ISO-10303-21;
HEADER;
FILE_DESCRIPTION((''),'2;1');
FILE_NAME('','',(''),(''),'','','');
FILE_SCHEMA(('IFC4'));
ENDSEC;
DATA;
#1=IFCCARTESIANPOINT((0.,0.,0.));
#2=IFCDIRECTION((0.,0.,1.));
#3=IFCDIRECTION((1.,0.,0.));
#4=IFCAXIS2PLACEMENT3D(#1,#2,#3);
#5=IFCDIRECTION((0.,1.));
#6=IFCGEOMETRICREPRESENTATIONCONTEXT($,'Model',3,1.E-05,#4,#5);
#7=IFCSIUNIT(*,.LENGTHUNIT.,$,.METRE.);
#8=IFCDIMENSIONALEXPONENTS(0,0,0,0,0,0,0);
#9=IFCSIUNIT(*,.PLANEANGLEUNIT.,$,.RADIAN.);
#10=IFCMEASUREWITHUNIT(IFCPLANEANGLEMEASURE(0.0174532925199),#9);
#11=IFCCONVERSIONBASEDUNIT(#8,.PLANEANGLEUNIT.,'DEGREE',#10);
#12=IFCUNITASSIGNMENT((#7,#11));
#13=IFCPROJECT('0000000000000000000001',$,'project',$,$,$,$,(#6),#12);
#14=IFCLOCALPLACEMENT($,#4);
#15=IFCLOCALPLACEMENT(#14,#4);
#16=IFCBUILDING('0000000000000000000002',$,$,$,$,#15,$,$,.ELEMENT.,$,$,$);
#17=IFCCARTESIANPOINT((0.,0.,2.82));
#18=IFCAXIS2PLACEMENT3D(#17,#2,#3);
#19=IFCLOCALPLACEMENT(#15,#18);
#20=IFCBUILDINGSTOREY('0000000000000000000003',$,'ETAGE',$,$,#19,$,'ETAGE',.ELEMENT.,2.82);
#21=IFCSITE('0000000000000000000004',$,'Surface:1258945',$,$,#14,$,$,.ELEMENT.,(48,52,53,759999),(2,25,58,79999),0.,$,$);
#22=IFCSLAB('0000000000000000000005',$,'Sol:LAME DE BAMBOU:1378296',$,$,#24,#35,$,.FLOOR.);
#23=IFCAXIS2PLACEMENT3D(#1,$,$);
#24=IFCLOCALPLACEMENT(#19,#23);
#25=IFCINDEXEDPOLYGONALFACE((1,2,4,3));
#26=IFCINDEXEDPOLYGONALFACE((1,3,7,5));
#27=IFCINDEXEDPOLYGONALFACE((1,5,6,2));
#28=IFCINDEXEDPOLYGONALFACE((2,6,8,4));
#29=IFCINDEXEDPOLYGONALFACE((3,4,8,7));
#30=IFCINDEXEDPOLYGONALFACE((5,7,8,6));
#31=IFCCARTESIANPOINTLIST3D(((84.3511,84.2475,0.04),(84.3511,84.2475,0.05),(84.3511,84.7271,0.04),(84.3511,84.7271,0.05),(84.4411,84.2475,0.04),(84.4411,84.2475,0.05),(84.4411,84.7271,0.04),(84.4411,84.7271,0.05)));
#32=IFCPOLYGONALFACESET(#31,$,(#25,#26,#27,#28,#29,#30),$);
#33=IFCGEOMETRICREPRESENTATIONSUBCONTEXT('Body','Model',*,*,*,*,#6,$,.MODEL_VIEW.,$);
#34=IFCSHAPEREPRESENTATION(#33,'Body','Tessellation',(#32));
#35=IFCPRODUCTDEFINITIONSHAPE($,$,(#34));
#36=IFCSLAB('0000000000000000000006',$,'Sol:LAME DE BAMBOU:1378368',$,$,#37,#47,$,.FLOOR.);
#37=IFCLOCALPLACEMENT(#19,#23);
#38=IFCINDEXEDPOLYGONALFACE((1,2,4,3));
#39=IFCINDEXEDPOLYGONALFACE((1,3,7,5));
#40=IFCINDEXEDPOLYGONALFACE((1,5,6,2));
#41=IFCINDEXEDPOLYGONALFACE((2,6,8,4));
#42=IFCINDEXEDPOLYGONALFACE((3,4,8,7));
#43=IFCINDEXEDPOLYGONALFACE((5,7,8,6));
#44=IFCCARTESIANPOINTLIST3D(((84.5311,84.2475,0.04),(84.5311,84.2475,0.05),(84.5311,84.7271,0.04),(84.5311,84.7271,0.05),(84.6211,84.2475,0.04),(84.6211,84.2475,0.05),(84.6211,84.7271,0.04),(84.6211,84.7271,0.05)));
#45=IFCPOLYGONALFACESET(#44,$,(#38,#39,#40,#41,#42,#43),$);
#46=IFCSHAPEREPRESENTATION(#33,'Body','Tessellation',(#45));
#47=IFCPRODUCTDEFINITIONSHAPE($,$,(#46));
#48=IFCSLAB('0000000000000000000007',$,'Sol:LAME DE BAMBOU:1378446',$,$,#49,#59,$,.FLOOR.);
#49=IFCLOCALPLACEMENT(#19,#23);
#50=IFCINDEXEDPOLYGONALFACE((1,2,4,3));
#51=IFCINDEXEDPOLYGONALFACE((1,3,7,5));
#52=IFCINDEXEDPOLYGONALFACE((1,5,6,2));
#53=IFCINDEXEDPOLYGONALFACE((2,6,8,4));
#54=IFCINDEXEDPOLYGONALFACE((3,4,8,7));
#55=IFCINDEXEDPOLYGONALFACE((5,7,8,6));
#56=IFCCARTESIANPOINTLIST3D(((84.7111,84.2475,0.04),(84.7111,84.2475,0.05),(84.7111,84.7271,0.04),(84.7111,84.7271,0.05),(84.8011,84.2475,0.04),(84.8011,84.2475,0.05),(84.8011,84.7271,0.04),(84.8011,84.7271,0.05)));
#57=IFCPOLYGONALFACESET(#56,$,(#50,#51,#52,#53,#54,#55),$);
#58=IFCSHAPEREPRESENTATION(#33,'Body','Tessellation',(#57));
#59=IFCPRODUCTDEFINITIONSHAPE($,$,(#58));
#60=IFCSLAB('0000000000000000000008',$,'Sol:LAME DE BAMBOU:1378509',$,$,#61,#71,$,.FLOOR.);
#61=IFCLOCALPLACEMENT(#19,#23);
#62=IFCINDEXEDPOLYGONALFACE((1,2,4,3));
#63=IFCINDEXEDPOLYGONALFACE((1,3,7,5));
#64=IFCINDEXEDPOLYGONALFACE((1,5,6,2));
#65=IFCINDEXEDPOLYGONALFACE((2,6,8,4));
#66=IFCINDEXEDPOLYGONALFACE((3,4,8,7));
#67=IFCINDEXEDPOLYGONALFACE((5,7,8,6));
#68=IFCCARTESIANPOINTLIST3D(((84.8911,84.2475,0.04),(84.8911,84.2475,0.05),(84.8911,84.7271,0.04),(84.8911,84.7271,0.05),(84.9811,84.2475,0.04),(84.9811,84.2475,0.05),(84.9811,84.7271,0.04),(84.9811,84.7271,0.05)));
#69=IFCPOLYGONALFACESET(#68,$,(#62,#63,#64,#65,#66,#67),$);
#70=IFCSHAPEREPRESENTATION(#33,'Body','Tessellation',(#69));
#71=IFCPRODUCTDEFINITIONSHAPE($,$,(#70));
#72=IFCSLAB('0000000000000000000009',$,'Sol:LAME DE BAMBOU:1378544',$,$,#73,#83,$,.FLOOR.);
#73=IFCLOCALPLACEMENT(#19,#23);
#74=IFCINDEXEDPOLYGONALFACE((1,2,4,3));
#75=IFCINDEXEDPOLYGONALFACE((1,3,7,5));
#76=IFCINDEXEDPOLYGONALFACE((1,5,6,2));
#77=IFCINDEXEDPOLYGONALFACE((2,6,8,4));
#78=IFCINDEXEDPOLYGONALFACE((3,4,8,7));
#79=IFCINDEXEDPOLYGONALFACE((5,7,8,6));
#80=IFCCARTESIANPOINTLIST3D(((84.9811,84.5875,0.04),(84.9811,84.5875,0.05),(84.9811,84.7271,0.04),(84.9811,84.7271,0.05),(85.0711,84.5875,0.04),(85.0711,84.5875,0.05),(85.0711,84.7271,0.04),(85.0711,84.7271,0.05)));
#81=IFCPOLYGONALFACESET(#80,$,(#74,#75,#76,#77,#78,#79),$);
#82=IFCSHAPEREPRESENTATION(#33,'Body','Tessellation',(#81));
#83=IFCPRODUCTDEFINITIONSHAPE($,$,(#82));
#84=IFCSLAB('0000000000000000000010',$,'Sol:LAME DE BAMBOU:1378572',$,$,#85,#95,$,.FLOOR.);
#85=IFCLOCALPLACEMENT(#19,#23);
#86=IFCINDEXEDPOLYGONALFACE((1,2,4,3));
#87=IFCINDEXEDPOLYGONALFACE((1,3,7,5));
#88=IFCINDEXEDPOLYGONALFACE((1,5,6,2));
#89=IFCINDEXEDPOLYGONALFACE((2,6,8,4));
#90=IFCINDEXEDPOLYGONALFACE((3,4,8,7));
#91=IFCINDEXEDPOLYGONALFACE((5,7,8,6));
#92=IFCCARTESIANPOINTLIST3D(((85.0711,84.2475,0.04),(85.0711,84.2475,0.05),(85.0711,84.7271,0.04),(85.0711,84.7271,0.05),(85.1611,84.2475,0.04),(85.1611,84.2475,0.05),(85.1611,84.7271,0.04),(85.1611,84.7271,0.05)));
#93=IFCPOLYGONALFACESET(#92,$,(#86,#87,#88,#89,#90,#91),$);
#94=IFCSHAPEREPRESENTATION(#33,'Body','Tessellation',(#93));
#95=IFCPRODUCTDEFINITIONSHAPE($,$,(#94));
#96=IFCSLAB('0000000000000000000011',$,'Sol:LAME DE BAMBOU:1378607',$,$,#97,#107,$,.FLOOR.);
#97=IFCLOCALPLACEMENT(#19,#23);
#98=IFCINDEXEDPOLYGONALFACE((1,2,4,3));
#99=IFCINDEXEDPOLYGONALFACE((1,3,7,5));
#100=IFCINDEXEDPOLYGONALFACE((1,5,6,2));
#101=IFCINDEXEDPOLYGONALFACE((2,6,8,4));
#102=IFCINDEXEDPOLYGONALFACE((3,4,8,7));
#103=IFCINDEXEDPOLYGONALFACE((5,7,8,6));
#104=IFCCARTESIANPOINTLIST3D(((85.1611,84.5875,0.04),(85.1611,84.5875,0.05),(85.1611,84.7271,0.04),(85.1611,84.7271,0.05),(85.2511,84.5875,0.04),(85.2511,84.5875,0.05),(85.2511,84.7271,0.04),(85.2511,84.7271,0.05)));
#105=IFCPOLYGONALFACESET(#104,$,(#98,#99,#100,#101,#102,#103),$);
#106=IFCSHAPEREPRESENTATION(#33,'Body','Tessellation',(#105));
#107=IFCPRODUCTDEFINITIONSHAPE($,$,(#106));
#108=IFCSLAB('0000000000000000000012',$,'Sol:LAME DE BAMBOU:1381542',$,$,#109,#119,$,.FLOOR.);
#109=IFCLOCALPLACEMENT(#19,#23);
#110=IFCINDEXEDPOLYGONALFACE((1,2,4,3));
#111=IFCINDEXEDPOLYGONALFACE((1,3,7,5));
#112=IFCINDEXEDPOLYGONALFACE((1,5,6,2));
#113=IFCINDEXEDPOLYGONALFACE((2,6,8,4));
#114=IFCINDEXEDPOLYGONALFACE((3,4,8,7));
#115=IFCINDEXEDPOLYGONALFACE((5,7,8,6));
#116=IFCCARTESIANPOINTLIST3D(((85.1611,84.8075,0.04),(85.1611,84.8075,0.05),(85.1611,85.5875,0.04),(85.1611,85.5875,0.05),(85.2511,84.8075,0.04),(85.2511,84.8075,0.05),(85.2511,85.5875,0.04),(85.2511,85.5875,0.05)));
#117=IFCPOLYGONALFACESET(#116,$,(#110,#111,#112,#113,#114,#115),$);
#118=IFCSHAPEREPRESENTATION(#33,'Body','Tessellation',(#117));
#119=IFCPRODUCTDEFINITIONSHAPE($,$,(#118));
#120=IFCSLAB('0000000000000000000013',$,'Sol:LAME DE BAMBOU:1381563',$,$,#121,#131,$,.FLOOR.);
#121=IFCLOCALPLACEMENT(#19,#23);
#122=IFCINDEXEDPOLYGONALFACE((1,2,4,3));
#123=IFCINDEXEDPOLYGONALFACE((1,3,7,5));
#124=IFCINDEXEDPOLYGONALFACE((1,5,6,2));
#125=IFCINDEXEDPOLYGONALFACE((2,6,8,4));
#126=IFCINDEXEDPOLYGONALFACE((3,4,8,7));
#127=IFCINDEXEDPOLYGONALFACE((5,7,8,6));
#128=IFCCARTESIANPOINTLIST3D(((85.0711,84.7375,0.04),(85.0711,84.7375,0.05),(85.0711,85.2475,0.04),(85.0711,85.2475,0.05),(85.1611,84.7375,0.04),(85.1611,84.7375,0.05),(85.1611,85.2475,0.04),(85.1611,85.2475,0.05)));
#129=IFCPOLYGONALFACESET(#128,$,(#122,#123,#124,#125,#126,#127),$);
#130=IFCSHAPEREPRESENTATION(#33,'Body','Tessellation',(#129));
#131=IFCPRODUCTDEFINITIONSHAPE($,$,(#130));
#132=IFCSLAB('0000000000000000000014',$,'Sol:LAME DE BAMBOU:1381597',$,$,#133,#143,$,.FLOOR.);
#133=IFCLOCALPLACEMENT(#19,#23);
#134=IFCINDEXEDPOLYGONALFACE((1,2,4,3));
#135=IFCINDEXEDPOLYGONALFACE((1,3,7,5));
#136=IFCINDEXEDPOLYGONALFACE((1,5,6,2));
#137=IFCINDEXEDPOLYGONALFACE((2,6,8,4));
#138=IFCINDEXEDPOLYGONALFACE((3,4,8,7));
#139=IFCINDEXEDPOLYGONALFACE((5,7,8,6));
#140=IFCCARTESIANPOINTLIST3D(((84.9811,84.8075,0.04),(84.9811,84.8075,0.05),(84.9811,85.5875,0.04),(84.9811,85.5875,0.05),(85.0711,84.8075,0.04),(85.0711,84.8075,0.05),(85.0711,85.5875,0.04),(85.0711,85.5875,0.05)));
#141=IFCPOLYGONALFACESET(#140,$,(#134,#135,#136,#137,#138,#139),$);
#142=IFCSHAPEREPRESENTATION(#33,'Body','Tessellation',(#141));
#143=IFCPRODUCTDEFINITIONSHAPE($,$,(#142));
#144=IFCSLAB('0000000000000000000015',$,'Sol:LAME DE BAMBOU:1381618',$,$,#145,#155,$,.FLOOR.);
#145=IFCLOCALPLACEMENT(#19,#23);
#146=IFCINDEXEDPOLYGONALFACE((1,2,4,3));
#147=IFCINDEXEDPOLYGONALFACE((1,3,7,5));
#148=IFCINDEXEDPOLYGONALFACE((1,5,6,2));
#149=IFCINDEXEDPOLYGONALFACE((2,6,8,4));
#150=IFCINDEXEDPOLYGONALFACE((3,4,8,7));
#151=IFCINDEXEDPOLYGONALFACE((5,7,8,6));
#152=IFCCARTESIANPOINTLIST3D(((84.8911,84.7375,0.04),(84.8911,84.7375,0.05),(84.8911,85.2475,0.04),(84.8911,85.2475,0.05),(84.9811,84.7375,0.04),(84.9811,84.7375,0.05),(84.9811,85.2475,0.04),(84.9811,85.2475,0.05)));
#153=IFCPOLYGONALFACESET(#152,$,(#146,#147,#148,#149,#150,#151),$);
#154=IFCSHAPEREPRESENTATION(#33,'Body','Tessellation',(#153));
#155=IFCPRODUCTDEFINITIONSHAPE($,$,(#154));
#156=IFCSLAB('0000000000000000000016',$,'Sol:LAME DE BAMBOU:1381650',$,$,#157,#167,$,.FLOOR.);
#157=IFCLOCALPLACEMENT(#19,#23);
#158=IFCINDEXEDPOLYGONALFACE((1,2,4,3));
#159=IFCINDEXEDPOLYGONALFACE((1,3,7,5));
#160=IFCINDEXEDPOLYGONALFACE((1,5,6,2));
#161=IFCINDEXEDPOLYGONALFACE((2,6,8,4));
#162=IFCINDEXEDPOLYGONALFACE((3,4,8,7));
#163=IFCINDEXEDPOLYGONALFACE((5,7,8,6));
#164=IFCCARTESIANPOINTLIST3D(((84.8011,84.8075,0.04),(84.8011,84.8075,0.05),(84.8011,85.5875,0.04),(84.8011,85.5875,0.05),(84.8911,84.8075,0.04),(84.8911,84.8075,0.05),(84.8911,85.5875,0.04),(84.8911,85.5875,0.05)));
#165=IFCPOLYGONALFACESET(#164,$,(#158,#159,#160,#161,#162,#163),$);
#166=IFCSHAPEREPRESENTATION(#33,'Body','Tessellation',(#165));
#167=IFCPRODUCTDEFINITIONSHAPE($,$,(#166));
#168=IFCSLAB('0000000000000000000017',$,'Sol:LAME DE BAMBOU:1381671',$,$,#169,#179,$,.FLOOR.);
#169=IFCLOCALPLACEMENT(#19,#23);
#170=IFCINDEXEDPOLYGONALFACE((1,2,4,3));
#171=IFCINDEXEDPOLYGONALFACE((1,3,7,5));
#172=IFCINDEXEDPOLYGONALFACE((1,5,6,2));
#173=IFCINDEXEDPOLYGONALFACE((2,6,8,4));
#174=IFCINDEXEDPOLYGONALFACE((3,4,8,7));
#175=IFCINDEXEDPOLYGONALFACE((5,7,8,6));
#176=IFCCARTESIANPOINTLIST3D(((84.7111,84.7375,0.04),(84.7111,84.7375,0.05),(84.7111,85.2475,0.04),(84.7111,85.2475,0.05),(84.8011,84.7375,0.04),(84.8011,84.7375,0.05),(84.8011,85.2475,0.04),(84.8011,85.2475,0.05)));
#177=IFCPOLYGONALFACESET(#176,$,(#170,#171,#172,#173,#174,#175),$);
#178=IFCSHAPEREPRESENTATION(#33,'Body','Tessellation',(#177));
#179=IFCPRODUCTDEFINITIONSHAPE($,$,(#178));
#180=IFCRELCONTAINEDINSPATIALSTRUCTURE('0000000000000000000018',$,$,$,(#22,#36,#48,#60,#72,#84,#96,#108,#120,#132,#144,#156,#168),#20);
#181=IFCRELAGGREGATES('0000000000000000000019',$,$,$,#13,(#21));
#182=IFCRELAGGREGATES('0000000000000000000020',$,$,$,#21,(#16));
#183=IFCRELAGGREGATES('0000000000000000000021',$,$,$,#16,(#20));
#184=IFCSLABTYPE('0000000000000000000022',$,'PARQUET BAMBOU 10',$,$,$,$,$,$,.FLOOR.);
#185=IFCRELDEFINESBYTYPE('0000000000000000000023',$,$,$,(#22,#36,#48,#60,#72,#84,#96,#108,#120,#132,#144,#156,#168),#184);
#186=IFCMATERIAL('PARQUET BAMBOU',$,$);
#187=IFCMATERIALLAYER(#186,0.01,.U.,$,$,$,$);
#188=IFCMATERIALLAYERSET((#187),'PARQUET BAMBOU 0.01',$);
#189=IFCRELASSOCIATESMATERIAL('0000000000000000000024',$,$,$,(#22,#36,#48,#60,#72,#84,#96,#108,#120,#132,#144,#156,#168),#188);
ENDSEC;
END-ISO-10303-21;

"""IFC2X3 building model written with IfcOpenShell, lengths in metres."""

from ifc_helpers import new_model, entity, si_unit, converted_unit, direction, frame, origin_with_axes, place, context, subcontext, project, spatial, polyline, outline, extrude, material, layer, layer_set, layer_usage, type_object, element, save


model = new_model("IFC2X3")

# Units and contexts
model_context = context("Model", 3, precision=1e-05, world=origin_with_axes(), true_north=direction((0.0, 1.0)))
body_context = subcontext(model_context, "Body", "Model", "MODEL_VIEW")
ifc_project = project(units=[si_unit("LENGTHUNIT", "METRE"), converted_unit("PLANEANGLEUNIT", "DEGREE", entity("IfcPlaneAngleMeasure", 0.0174532925199), si_unit("PLANEANGLEUNIT", "RADIAN"), dimensions=[0, 0, 0, 0, 0, 0, 0])], contexts=[model_context])

# Site, building, storey
site_placement = place(None, origin_with_axes())
site = spatial("IfcSite", under=ifc_project, at=site_placement, Name="Surface:1258945", CompositionType="ELEMENT", RefLatitude=(48, 52, 53, 759999), RefLongitude=(2, 25, 58, 79999), RefElevation=0.0)
building_placement = place(site_placement, origin_with_axes())
building = spatial("IfcBuilding", under=site, at=building_placement, CompositionType="ELEMENT")
storey_placement = place(building_placement, frame((0.0, 0.0, 2.82), z_axis=(0.0, 0.0, 1.0), x_axis=(1.0, 0.0, 0.0)))
storey = spatial("IfcBuildingStorey", under=building, at=storey_placement, Name="ETAGE", LongName="ETAGE", CompositionType="ELEMENT", Elevation=2.82)

# Slabs
ifc_material_1 = material(Name="PARQUET BAMBOU")
ifc_layer_1 = layer(ifc_material_1, 0.01, ventilated="UNKNOWN")
ifc_layer_set_1 = layer_set([ifc_layer_1], Name="PARQUET BAMBOU 0.01")
ifc_layer_usage_1 = layer_usage(ifc_layer_set_1, "AXIS3", "NEGATIVE", 0.01)
slab_type = type_object("IfcSlabType", Name="PARQUET BAMBOU 10", PredefinedType="FLOOR")
slab_1_placement = place(storey_placement, frame((84.3511, 84.7271, 0.05), z_axis=(0.0, 0.0, 1.0), x_axis=(1.0, 0.0, 0.0)))
element("IfcSlab", 1, at=slab_1_placement, inside=storey, type_object=slab_type, material=ifc_layer_usage_1, Name="Sol:LAME DE BAMBOU:1378296", PredefinedType="FLOOR", context=body_context, shape_type="SweptSolid", body=[
    extrude(outline(polyline([(0.0, 0.0), (0.0, -0.4796), (0.09, -0.4796), (0.09, 0.0), (0.0, 0.0)])), frame((0.0, 0.0, -0.01), z_axis=(0.0, 0.0, 1.0), x_axis=(1.0, 0.0, 0.0)), (0.0, 0.0, 1.0), 0.01),
])
ifc_layer_usage_2 = layer_usage(ifc_layer_set_1, "AXIS3", "NEGATIVE", 0.01)
slab_2_placement = place(storey_placement, frame((84.5311, 84.7271, 0.05), z_axis=(0.0, 0.0, 1.0), x_axis=(1.0, 0.0, 0.0)))
element("IfcSlab", 2, at=slab_2_placement, inside=storey, type_object=slab_type, material=ifc_layer_usage_2, Name="Sol:LAME DE BAMBOU:1378368", PredefinedType="FLOOR", context=body_context, shape_type="SweptSolid", body=[
    extrude(outline(polyline([(0.0, 0.0), (0.0, -0.4796), (0.09, -0.4796), (0.09, 0.0), (0.0, 0.0)])), frame((0.0, 0.0, -0.01), z_axis=(0.0, 0.0, 1.0), x_axis=(1.0, 0.0, 0.0)), (0.0, 0.0, 1.0), 0.01),
])
ifc_layer_usage_3 = layer_usage(ifc_layer_set_1, "AXIS3", "NEGATIVE", 0.01)
slab_3_placement = place(storey_placement, frame((84.7111, 84.7271, 0.05), z_axis=(0.0, 0.0, 1.0), x_axis=(1.0, 0.0, 0.0)))
element("IfcSlab", 3, at=slab_3_placement, inside=storey, type_object=slab_type, material=ifc_layer_usage_3, Name="Sol:LAME DE BAMBOU:1378446", PredefinedType="FLOOR", context=body_context, shape_type="SweptSolid", body=[
    extrude(outline(polyline([(0.0, 0.0), (0.0, -0.4796), (0.09, -0.4796), (0.09, 0.0), (0.0, 0.0)])), frame((0.0, 0.0, -0.01), z_axis=(0.0, 0.0, 1.0), x_axis=(1.0, 0.0, 0.0)), (0.0, 0.0, 1.0), 0.01),
])
ifc_layer_usage_4 = layer_usage(ifc_layer_set_1, "AXIS3", "NEGATIVE", 0.01)
slab_4_placement = place(storey_placement, frame((84.8911, 84.7271, 0.05), z_axis=(0.0, 0.0, 1.0), x_axis=(1.0, 0.0, 0.0)))
element("IfcSlab", 4, at=slab_4_placement, inside=storey, type_object=slab_type, material=ifc_layer_usage_4, Name="Sol:LAME DE BAMBOU:1378509", PredefinedType="FLOOR", context=body_context, shape_type="SweptSolid", body=[
    extrude(outline(polyline([(0.0, 0.0), (0.0, -0.4796), (0.09, -0.4796), (0.09, 0.0), (0.0, 0.0)])), frame((0.0, 0.0, -0.01), z_axis=(0.0, 0.0, 1.0), x_axis=(1.0, 0.0, 0.0)), (0.0, 0.0, 1.0), 0.01),
])
ifc_layer_usage_5 = layer_usage(ifc_layer_set_1, "AXIS3", "NEGATIVE", 0.01)
slab_5_placement = place(storey_placement, frame((84.9811, 84.7271, 0.05), z_axis=(0.0, 0.0, 1.0), x_axis=(1.0, 0.0, 0.0)))
element("IfcSlab", 5, at=slab_5_placement, inside=storey, type_object=slab_type, material=ifc_layer_usage_5, Name="Sol:LAME DE BAMBOU:1378544", PredefinedType="FLOOR", context=body_context, shape_type="SweptSolid", body=[
    extrude(outline(polyline([(0.0, 0.0), (0.0, -0.1396), (0.09, -0.1396), (0.09, 0.0), (0.0, 0.0)])), frame((0.0, 0.0, -0.01), z_axis=(0.0, 0.0, 1.0), x_axis=(1.0, 0.0, 0.0)), (0.0, 0.0, 1.0), 0.01),
])
ifc_layer_usage_6 = layer_usage(ifc_layer_set_1, "AXIS3", "NEGATIVE", 0.01)
slab_6_placement = place(storey_placement, frame((85.0711, 84.7271, 0.05), z_axis=(0.0, 0.0, 1.0), x_axis=(1.0, 0.0, 0.0)))
element("IfcSlab", 6, at=slab_6_placement, inside=storey, type_object=slab_type, material=ifc_layer_usage_6, Name="Sol:LAME DE BAMBOU:1378572", PredefinedType="FLOOR", context=body_context, shape_type="SweptSolid", body=[
    extrude(outline(polyline([(0.0, 0.0), (0.0, -0.4796), (0.09, -0.4796), (0.09, 0.0), (0.0, 0.0)])), frame((0.0, 0.0, -0.01), z_axis=(0.0, 0.0, 1.0), x_axis=(1.0, 0.0, 0.0)), (0.0, 0.0, 1.0), 0.01),
])
ifc_layer_usage_7 = layer_usage(ifc_layer_set_1, "AXIS3", "NEGATIVE", 0.01)
slab_7_placement = place(storey_placement, frame((85.1611, 84.7271, 0.05), z_axis=(0.0, 0.0, 1.0), x_axis=(1.0, 0.0, 0.0)))
element("IfcSlab", 7, at=slab_7_placement, inside=storey, type_object=slab_type, material=ifc_layer_usage_7, Name="Sol:LAME DE BAMBOU:1378607", PredefinedType="FLOOR", context=body_context, shape_type="SweptSolid", body=[
    extrude(outline(polyline([(0.0, 0.0), (0.0, -0.1396), (0.09, -0.1396), (0.09, 0.0), (0.0, 0.0)])), frame((0.0, 0.0, -0.01), z_axis=(0.0, 0.0, 1.0), x_axis=(1.0, 0.0, 0.0)), (0.0, 0.0, 1.0), 0.01),
])
ifc_layer_usage_8 = layer_usage(ifc_layer_set_1, "AXIS3", "NEGATIVE", 0.01)
slab_8_placement = place(storey_placement, frame((85.1611, 85.5875, 0.05), z_axis=(0.0, 0.0, 1.0), x_axis=(1.0, 0.0, 0.0)))
element("IfcSlab", 8, at=slab_8_placement, inside=storey, type_object=slab_type, material=ifc_layer_usage_8, Name="Sol:LAME DE BAMBOU:1381542", PredefinedType="FLOOR", context=body_context, shape_type="SweptSolid", body=[
    extrude(outline(polyline([(0.0, 0.0), (0.0, -0.78), (0.09, -0.78), (0.09, 0.0), (0.0, 0.0)])), frame((0.0, 0.0, -0.01), z_axis=(0.0, 0.0, 1.0), x_axis=(1.0, 0.0, 0.0)), (0.0, 0.0, 1.0), 0.01),
])
ifc_layer_usage_9 = layer_usage(ifc_layer_set_1, "AXIS3", "NEGATIVE", 0.01)
slab_9_placement = place(storey_placement, frame((85.0711, 85.2475, 0.05), z_axis=(0.0, 0.0, 1.0), x_axis=(1.0, 0.0, 0.0)))
element("IfcSlab", 9, at=slab_9_placement, inside=storey, type_object=slab_type, material=ifc_layer_usage_9, Name="Sol:LAME DE BAMBOU:1381563", PredefinedType="FLOOR", context=body_context, shape_type="SweptSolid", body=[
    extrude(outline(polyline([(0.0, 0.0), (0.0, -0.51), (0.09, -0.51), (0.09, 0.0), (0.0, 0.0)])), frame((0.0, 0.0, -0.01), z_axis=(0.0, 0.0, 1.0), x_axis=(1.0, 0.0, 0.0)), (0.0, 0.0, 1.0), 0.01),
])
ifc_layer_usage_10 = layer_usage(ifc_layer_set_1, "AXIS3", "NEGATIVE", 0.01)
slab_10_placement = place(storey_placement, frame((84.9811, 85.5875, 0.05), z_axis=(0.0, 0.0, 1.0), x_axis=(1.0, 0.0, 0.0)))
element("IfcSlab", 10, at=slab_10_placement, inside=storey, type_object=slab_type, material=ifc_layer_usage_10, Name="Sol:LAME DE BAMBOU:1381597", PredefinedType="FLOOR", context=body_context, shape_type="SweptSolid", body=[
    extrude(outline(polyline([(0.0, 0.0), (0.0, -0.78), (0.09, -0.78), (0.09, 0.0), (0.0, 0.0)])), frame((0.0, 0.0, -0.01), z_axis=(0.0, 0.0, 1.0), x_axis=(1.0, 0.0, 0.0)), (0.0, 0.0, 1.0), 0.01),
])
ifc_layer_usage_11 = layer_usage(ifc_layer_set_1, "AXIS3", "NEGATIVE", 0.01)
slab_11_placement = place(storey_placement, frame((84.8911, 85.2475, 0.05), z_axis=(0.0, 0.0, 1.0), x_axis=(1.0, 0.0, 0.0)))
element("IfcSlab", 11, at=slab_11_placement, inside=storey, type_object=slab_type, material=ifc_layer_usage_11, Name="Sol:LAME DE BAMBOU:1381618", PredefinedType="FLOOR", context=body_context, shape_type="SweptSolid", body=[
    extrude(outline(polyline([(0.0, 0.0), (0.0, -0.51), (0.09, -0.51), (0.09, 0.0), (0.0, 0.0)])), frame((0.0, 0.0, -0.01), z_axis=(0.0, 0.0, 1.0), x_axis=(1.0, 0.0, 0.0)), (0.0, 0.0, 1.0), 0.01),
])
ifc_layer_usage_12 = layer_usage(ifc_layer_set_1, "AXIS3", "NEGATIVE", 0.01)
slab_12_placement = place(storey_placement, frame((84.8011, 85.5875, 0.05), z_axis=(0.0, 0.0, 1.0), x_axis=(1.0, 0.0, 0.0)))
element("IfcSlab", 12, at=slab_12_placement, inside=storey, type_object=slab_type, material=ifc_layer_usage_12, Name="Sol:LAME DE BAMBOU:1381650", PredefinedType="FLOOR", context=body_context, shape_type="SweptSolid", body=[
    extrude(outline(polyline([(0.0, 0.0), (0.0, -0.78), (0.09, -0.78), (0.09, 0.0), (0.0, 0.0)])), frame((0.0, 0.0, -0.01), z_axis=(0.0, 0.0, 1.0), x_axis=(1.0, 0.0, 0.0)), (0.0, 0.0, 1.0), 0.01),
])
ifc_layer_usage_13 = layer_usage(ifc_layer_set_1, "AXIS3", "NEGATIVE", 0.01)
slab_13_placement = place(storey_placement, frame((84.7111, 85.2475, 0.05), z_axis=(0.0, 0.0, 1.0), x_axis=(1.0, 0.0, 0.0)))
element("IfcSlab", 13, at=slab_13_placement, inside=storey, type_object=slab_type, material=ifc_layer_usage_13, Name="Sol:LAME DE BAMBOU:1381671", PredefinedType="FLOOR", context=body_context, shape_type="SweptSolid", body=[
    extrude(outline(polyline([(0.0, 0.0), (0.0, -0.51), (0.09, -0.51), (0.09, 0.0), (0.0, 0.0)])), frame((0.0, 0.0, -0.01), z_axis=(0.0, 0.0, 1.0), x_axis=(1.0, 0.0, 0.0)), (0.0, 0.0, 1.0), 0.01),
])

save(model, "model.ifc")
